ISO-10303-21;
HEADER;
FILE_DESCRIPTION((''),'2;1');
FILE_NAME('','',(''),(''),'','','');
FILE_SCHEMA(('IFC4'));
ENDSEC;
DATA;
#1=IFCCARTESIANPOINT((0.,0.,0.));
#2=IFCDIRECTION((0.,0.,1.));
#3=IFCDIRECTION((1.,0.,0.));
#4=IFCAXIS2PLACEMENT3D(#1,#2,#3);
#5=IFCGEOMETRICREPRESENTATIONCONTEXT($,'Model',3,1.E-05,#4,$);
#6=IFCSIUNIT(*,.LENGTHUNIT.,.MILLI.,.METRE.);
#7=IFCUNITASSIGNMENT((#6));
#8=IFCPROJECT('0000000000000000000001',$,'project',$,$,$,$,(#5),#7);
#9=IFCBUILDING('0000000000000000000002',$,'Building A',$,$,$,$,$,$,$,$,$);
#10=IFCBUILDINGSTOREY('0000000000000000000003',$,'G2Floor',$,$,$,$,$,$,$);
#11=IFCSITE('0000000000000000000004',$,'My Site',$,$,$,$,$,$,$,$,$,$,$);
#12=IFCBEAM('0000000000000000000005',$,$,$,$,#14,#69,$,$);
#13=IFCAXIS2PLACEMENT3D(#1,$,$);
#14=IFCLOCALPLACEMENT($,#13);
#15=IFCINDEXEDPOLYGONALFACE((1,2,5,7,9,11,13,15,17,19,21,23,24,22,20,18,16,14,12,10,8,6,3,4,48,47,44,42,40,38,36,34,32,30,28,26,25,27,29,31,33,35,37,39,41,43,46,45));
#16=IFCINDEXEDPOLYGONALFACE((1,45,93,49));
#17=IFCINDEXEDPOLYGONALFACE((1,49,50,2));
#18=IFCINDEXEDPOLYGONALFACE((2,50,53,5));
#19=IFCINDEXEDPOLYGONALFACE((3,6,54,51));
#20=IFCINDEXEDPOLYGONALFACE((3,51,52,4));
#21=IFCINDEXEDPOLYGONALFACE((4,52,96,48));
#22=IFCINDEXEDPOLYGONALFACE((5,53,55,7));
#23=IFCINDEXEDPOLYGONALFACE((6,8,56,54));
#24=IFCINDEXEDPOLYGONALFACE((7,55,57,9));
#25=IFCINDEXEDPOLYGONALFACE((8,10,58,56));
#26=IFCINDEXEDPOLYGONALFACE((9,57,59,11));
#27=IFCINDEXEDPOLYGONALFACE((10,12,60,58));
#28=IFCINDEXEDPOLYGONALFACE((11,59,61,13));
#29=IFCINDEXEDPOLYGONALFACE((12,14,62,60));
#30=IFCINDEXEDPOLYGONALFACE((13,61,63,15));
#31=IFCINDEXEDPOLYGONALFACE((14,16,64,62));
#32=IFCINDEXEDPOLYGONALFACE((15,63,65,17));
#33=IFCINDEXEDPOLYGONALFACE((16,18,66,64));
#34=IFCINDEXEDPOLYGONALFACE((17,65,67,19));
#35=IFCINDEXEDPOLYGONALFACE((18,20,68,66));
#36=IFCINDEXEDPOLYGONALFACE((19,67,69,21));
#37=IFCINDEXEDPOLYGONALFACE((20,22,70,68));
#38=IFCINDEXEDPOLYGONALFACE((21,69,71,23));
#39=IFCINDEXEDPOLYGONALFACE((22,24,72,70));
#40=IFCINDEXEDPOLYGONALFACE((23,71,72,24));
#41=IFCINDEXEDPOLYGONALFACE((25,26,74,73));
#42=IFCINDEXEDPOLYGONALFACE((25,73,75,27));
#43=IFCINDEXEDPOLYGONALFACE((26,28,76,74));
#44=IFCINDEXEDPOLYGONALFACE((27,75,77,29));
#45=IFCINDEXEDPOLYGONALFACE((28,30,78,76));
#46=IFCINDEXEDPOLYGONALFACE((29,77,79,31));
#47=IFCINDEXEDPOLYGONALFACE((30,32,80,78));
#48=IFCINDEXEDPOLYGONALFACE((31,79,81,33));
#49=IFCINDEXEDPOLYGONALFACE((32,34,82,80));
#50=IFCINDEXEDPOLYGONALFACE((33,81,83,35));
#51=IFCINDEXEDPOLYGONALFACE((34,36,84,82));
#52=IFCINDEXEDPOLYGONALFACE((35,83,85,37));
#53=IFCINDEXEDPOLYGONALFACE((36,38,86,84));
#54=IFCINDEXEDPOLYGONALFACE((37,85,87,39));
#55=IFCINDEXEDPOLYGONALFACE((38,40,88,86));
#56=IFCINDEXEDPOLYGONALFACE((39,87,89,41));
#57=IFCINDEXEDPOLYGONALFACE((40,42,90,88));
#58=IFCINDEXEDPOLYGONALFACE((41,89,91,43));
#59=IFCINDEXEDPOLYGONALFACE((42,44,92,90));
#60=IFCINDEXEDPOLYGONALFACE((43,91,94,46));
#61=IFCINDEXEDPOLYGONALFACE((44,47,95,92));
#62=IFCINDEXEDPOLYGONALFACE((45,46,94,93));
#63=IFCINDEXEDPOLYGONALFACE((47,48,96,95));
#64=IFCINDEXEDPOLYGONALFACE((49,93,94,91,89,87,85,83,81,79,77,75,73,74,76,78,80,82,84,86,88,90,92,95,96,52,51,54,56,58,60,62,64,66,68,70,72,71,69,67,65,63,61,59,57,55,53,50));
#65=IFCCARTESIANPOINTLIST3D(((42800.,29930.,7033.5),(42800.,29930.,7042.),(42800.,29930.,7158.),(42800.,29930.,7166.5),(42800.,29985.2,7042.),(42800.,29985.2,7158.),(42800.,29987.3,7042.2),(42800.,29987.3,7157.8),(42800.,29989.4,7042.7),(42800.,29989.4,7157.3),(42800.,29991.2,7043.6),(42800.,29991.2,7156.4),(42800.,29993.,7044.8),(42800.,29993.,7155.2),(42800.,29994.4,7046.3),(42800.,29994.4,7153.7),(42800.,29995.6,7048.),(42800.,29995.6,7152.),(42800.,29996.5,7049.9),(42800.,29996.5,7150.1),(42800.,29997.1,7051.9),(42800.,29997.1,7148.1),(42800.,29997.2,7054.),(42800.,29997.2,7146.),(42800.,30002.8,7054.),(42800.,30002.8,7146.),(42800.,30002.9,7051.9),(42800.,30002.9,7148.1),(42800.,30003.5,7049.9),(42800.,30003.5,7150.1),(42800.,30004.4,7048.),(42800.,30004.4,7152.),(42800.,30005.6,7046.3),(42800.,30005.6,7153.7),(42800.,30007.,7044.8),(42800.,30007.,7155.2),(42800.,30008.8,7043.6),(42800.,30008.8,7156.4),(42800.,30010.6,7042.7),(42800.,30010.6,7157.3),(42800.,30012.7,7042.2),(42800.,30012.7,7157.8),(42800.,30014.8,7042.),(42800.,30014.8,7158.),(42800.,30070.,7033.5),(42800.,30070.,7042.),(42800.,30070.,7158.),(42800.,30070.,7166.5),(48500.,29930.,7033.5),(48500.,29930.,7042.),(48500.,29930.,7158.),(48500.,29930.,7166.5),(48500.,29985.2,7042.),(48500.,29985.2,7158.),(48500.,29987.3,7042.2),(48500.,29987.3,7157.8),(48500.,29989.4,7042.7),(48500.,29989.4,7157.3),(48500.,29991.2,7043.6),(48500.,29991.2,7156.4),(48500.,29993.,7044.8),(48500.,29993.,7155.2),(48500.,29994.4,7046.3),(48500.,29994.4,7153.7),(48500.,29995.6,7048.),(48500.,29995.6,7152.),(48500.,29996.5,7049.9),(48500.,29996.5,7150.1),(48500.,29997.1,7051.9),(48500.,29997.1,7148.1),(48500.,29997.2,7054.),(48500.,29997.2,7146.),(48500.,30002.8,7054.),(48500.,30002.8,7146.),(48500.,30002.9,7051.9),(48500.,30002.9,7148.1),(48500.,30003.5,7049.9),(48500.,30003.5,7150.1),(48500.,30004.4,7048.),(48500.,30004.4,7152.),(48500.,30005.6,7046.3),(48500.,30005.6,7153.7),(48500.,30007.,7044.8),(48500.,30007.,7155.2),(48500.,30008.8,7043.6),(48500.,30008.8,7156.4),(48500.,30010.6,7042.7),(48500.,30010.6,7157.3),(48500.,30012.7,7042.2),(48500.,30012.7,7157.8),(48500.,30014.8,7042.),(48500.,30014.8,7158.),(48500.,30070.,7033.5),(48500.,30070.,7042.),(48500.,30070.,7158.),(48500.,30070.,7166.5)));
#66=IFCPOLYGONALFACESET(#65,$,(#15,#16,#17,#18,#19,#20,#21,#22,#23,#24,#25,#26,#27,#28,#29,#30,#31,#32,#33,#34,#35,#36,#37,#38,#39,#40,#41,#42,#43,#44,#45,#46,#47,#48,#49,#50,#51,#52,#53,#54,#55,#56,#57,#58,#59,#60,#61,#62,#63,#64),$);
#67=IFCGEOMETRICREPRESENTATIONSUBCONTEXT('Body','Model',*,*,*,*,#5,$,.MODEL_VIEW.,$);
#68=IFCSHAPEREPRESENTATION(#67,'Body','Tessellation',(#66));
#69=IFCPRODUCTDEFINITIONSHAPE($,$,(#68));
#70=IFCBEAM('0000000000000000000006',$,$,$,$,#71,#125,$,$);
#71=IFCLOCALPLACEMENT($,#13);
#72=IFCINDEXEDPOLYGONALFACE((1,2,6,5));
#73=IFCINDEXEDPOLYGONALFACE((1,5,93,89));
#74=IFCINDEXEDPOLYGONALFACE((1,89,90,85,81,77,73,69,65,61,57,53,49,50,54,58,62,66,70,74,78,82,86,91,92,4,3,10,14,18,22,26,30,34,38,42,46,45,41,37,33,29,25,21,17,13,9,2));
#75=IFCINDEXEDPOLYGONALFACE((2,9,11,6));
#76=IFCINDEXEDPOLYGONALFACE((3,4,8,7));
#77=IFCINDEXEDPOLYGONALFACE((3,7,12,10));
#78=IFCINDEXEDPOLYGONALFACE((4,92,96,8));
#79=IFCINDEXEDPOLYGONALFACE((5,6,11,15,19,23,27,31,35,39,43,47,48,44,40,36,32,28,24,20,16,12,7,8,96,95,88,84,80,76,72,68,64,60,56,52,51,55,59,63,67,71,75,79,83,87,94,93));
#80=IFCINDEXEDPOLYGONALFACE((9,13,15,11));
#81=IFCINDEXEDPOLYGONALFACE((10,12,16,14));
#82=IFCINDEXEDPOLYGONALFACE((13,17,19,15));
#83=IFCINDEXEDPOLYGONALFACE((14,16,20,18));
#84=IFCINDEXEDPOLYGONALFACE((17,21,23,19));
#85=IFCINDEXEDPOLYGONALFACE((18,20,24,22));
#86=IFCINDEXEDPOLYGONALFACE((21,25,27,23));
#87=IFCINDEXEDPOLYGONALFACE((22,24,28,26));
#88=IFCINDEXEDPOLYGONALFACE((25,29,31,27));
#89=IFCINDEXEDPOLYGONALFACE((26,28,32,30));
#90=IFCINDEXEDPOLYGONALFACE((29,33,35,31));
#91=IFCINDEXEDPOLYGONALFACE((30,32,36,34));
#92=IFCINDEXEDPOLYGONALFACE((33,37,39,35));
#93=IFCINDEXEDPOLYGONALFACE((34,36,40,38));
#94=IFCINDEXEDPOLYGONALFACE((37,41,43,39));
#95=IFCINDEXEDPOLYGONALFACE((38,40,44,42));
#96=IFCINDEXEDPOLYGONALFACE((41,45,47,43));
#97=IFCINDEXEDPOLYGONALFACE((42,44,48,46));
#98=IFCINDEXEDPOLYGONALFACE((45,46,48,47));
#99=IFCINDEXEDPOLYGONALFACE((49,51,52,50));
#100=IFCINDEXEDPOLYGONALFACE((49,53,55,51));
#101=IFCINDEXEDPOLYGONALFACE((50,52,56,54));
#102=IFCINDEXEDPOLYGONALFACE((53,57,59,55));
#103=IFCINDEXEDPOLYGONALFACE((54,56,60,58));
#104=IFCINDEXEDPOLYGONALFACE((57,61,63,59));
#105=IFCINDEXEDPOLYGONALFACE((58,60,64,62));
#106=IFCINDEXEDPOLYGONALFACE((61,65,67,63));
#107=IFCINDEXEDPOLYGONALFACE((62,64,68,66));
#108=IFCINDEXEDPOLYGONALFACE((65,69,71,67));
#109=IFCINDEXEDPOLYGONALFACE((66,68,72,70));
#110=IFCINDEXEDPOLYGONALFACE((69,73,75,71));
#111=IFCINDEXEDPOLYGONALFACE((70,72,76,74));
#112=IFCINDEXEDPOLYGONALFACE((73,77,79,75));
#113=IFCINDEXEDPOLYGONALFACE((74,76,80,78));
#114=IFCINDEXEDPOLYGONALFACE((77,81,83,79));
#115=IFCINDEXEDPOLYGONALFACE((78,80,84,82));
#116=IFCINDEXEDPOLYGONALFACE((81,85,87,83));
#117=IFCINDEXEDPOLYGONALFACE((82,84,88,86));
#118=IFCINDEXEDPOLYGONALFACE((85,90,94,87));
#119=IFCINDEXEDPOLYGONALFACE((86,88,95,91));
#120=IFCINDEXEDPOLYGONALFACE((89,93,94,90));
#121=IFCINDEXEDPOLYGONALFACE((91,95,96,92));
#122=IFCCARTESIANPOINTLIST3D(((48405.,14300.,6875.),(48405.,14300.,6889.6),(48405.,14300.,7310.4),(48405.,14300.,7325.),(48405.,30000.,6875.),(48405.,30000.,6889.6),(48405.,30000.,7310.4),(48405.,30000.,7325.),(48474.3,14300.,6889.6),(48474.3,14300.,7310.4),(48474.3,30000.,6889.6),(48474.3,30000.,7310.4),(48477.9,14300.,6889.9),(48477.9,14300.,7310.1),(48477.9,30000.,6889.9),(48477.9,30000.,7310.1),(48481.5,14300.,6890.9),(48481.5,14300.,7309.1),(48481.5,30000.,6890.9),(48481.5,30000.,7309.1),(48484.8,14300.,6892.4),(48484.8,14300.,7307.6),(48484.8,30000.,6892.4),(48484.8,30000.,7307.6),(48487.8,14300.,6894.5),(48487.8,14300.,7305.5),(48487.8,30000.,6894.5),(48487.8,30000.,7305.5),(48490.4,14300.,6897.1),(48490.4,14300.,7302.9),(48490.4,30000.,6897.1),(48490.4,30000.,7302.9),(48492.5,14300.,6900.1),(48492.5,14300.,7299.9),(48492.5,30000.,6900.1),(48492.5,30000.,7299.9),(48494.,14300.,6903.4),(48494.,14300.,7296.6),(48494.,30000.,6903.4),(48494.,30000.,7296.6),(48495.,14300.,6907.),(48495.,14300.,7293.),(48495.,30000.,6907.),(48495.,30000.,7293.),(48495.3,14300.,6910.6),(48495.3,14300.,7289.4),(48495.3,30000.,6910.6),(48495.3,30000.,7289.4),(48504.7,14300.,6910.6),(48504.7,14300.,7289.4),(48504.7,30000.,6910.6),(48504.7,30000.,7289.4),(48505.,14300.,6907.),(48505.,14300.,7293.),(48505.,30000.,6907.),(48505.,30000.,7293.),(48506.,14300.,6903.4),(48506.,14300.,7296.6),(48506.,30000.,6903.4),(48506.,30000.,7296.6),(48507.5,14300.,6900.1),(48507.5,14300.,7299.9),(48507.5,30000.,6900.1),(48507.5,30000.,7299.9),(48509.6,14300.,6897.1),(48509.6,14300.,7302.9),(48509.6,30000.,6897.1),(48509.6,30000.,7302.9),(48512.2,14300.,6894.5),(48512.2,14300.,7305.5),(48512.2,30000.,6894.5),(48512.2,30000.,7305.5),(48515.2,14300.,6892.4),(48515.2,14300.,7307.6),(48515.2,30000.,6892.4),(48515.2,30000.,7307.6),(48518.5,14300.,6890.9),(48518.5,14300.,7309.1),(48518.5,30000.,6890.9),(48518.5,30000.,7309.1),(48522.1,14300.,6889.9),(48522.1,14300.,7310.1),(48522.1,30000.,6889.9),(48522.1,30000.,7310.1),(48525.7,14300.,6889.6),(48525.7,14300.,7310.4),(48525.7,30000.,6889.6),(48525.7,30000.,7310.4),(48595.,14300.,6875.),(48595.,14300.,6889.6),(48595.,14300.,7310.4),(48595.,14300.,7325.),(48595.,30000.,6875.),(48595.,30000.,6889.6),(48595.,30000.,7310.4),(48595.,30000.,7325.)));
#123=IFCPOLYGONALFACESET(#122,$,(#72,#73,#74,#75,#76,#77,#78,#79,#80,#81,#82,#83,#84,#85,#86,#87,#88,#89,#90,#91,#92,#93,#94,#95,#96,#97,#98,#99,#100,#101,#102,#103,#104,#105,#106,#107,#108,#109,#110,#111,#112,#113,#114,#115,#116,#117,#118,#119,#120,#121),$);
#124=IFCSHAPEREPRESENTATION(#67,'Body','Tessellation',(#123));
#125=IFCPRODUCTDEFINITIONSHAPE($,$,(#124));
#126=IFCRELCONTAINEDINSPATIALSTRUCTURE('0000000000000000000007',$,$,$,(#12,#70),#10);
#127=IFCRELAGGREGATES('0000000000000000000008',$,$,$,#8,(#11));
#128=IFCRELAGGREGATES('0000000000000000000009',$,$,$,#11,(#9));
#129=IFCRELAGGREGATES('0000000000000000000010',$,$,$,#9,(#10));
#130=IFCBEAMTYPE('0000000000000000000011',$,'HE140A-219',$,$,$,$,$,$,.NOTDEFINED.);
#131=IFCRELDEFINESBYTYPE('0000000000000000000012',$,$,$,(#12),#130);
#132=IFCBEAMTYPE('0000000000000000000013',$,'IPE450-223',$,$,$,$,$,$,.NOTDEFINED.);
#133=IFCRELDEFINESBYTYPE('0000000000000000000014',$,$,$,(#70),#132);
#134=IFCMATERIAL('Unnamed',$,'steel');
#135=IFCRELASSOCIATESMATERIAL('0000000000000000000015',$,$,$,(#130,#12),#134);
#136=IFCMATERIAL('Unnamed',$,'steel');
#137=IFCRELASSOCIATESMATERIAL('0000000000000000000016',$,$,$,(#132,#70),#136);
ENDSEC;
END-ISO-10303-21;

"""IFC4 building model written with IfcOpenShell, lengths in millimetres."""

from ifc_helpers import new_model, si_unit, frame, origin_with_axes, place, context, subcontext, project, spatial, polyline, outline, extrude, material, material_profile, profile_set, profile_usage, type_object, element, save


model = new_model("IFC4")

# Units and contexts
model_context = context("Model", 3, precision=1e-05, world=origin_with_axes())
body_context = subcontext(model_context, "Body", "Model", "MODEL_VIEW")
ifc_project = project(units=[si_unit("LENGTHUNIT", "METRE", prefix="MILLI")], contexts=[model_context])

# Site, building, storey
site = spatial("IfcSite", under=ifc_project, Name="My Site")
building = spatial("IfcBuilding", under=site, Name="Building A")
storey = spatial("IfcBuildingStorey", under=building, Name="G2Floor")

# Beams
ifc_material_1 = material(Name="Unnamed", Category="steel")
ifc_material_profile_1 = material_profile(ifc_material_1, outline(polyline([(70.0, -66.5), (70.0, -58.0), (70.0, -58.0), (14.8, -58.0), (14.8, -58.0), (12.7, -57.8), (12.7, -57.8), (10.6, -57.3), (10.6, -57.3), (8.8, -56.4), (8.8, -56.4), (7.0, -55.2), (7.0, -55.2), (5.6, -53.7), (5.6, -53.7), (4.4, -52.0), (4.4, -52.0), (3.5, -50.1), (3.5, -50.1), (2.9, -48.1), (2.9, -48.1), (2.8, -46.0), (2.8, -46.0), (2.8, 46.0), (2.8, 46.0), (2.9, 48.1), (2.9, 48.1), (3.5, 50.1), (3.5, 50.1), (4.4, 52.0), (4.4, 52.0), (5.6, 53.7), (5.6, 53.7), (7.0, 55.2), (7.0, 55.2), (8.8, 56.4), (8.8, 56.4), (10.6, 57.3), (10.6, 57.3), (12.7, 57.8), (12.7, 57.8), (14.8, 58.0), (14.8, 58.0), (70.0, 58.0), (70.0, 58.0), (70.0, 66.5), (70.0, 66.5), (-70.0, 66.5), (-70.0, 66.5), (-70.0, 58.0), (-70.0, 58.0), (-14.8, 58.0), (-14.8, 58.0), (-12.7, 57.8), (-12.7, 57.8), (-10.6, 57.3), (-10.6, 57.3), (-8.8, 56.4), (-8.8, 56.4), (-7.0, 55.2), (-7.0, 55.2), (-5.6, 53.7), (-5.6, 53.7), (-4.4, 52.0), (-4.4, 52.0), (-3.5, 50.1), (-3.5, 50.1), (-2.9, 48.1), (-2.9, 48.1), (-2.8, 46.0), (-2.8, 46.0), (-2.8, -46.0), (-2.8, -46.0), (-2.9, -48.1), (-2.9, -48.1), (-3.5, -50.1), (-3.5, -50.1), (-4.4, -52.0), (-4.4, -52.0), (-5.6, -53.7), (-5.6, -53.7), (-7.0, -55.2), (-7.0, -55.2), (-8.8, -56.4), (-8.8, -56.4), (-10.6, -57.3), (-10.6, -57.3), (-12.7, -57.8), (-12.7, -57.8), (-14.8, -58.0), (-14.8, -58.0), (-70.0, -58.0), (-70.0, -58.0), (-70.0, -66.5), (-70.0, -66.5), (70.0, -66.5)])))
ifc_profile_set_1 = profile_set([ifc_material_profile_1], Name="HE140A-219")
ifc_profile_usage_1 = profile_usage(ifc_profile_set_1)
beam_type_1 = type_object("IfcBeamType", Name="HE140A-219", PredefinedType="NOTDEFINED", material=ifc_profile_set_1)
beam_1_placement = place(None, frame((42800.0, 30000.0, 7100.0), z_axis=(1.0, 0.0, 0.0), x_axis=(0.0, -1.0, 0.0)))
element("IfcBeam", 1, at=beam_1_placement, inside=storey, type_object=beam_type_1, material=ifc_profile_usage_1, context=body_context, shape_type="SweptSolid", body=[
    extrude(outline(polyline([(70.0, -66.5), (70.0, -58.0), (70.0, -58.0), (14.8, -58.0), (14.8, -58.0), (12.7, -57.8), (12.7, -57.8), (10.6, -57.3), (10.6, -57.3), (8.8, -56.4), (8.8, -56.4), (7.0, -55.2), (7.0, -55.2), (5.6, -53.7), (5.6, -53.7), (4.4, -52.0), (4.4, -52.0), (3.5, -50.1), (3.5, -50.1), (2.9, -48.1), (2.9, -48.1), (2.8, -46.0), (2.8, -46.0), (2.8, 46.0), (2.8, 46.0), (2.9, 48.1), (2.9, 48.1), (3.5, 50.1), (3.5, 50.1), (4.4, 52.0), (4.4, 52.0), (5.6, 53.7), (5.6, 53.7), (7.0, 55.2), (7.0, 55.2), (8.8, 56.4), (8.8, 56.4), (10.6, 57.3), (10.6, 57.3), (12.7, 57.8), (12.7, 57.8), (14.8, 58.0), (14.8, 58.0), (70.0, 58.0), (70.0, 58.0), (70.0, 66.5), (70.0, 66.5), (-70.0, 66.5), (-70.0, 66.5), (-70.0, 58.0), (-70.0, 58.0), (-14.8, 58.0), (-14.8, 58.0), (-12.7, 57.8), (-12.7, 57.8), (-10.6, 57.3), (-10.6, 57.3), (-8.8, 56.4), (-8.8, 56.4), (-7.0, 55.2), (-7.0, 55.2), (-5.6, 53.7), (-5.6, 53.7), (-4.4, 52.0), (-4.4, 52.0), (-3.5, 50.1), (-3.5, 50.1), (-2.9, 48.1), (-2.9, 48.1), (-2.8, 46.0), (-2.8, 46.0), (-2.8, -46.0), (-2.8, -46.0), (-2.9, -48.1), (-2.9, -48.1), (-3.5, -50.1), (-3.5, -50.1), (-4.4, -52.0), (-4.4, -52.0), (-5.6, -53.7), (-5.6, -53.7), (-7.0, -55.2), (-7.0, -55.2), (-8.8, -56.4), (-8.8, -56.4), (-10.6, -57.3), (-10.6, -57.3), (-12.7, -57.8), (-12.7, -57.8), (-14.8, -58.0), (-14.8, -58.0), (-70.0, -58.0), (-70.0, -58.0), (-70.0, -66.5), (-70.0, -66.5), (70.0, -66.5)])), origin_with_axes(), (0.0, 0.0, 1.0), 5700.0),
])
ifc_material_2 = material(Name="Unnamed", Category="steel")
ifc_material_profile_2 = material_profile(ifc_material_2, outline(polyline([(95.0, -225.0), (95.0, -210.4), (95.0, -210.4), (25.7, -210.4), (25.7, -210.4), (22.1, -210.1), (22.1, -210.1), (18.5, -209.1), (18.5, -209.1), (15.2, -207.6), (15.2, -207.6), (12.2, -205.5), (12.2, -205.5), (9.6, -202.9), (9.6, -202.9), (7.5, -199.9), (7.5, -199.9), (6.0, -196.6), (6.0, -196.6), (5.0, -193.0), (5.0, -193.0), (4.7, -189.4), (4.7, -189.4), (4.7, 189.4), (4.7, 189.4), (5.0, 193.0), (5.0, 193.0), (6.0, 196.6), (6.0, 196.6), (7.5, 199.9), (7.5, 199.9), (9.6, 202.9), (9.6, 202.9), (12.2, 205.5), (12.2, 205.5), (15.2, 207.6), (15.2, 207.6), (18.5, 209.1), (18.5, 209.1), (22.1, 210.1), (22.1, 210.1), (25.7, 210.4), (25.7, 210.4), (95.0, 210.4), (95.0, 210.4), (95.0, 225.0), (95.0, 225.0), (-95.0, 225.0), (-95.0, 225.0), (-95.0, 210.4), (-95.0, 210.4), (-25.7, 210.4), (-25.7, 210.4), (-22.1, 210.1), (-22.1, 210.1), (-18.5, 209.1), (-18.5, 209.1), (-15.2, 207.6), (-15.2, 207.6), (-12.2, 205.5), (-12.2, 205.5), (-9.6, 202.9), (-9.6, 202.9), (-7.5, 199.9), (-7.5, 199.9), (-6.0, 196.6), (-6.0, 196.6), (-5.0, 193.0), (-5.0, 193.0), (-4.7, 189.4), (-4.7, 189.4), (-4.7, -189.4), (-4.7, -189.4), (-5.0, -193.0), (-5.0, -193.0), (-6.0, -196.6), (-6.0, -196.6), (-7.5, -199.9), (-7.5, -199.9), (-9.6, -202.9), (-9.6, -202.9), (-12.2, -205.5), (-12.2, -205.5), (-15.2, -207.6), (-15.2, -207.6), (-18.5, -209.1), (-18.5, -209.1), (-22.1, -210.1), (-22.1, -210.1), (-25.7, -210.4), (-25.7, -210.4), (-95.0, -210.4), (-95.0, -210.4), (-95.0, -225.0), (-95.0, -225.0), (95.0, -225.0)])))
ifc_profile_set_2 = profile_set([ifc_material_profile_2], Name="IPE450-223")
ifc_profile_usage_2 = profile_usage(ifc_profile_set_2)
beam_type_2 = type_object("IfcBeamType", Name="IPE450-223", PredefinedType="NOTDEFINED", material=ifc_profile_set_2)
beam_2_placement = place(None, frame((48500.0, 14300.0, 7100.0), z_axis=(0.0, 1.0, 0.0), x_axis=(1.0, 0.0, 0.0)))
element("IfcBeam", 2, at=beam_2_placement, inside=storey, type_object=beam_type_2, material=ifc_profile_usage_2, context=body_context, shape_type="SweptSolid", body=[
    extrude(outline(polyline([(95.0, -225.0), (95.0, -210.4), (95.0, -210.4), (25.7, -210.4), (25.7, -210.4), (22.1, -210.1), (22.1, -210.1), (18.5, -209.1), (18.5, -209.1), (15.2, -207.6), (15.2, -207.6), (12.2, -205.5), (12.2, -205.5), (9.6, -202.9), (9.6, -202.9), (7.5, -199.9), (7.5, -199.9), (6.0, -196.6), (6.0, -196.6), (5.0, -193.0), (5.0, -193.0), (4.7, -189.4), (4.7, -189.4), (4.7, 189.4), (4.7, 189.4), (5.0, 193.0), (5.0, 193.0), (6.0, 196.6), (6.0, 196.6), (7.5, 199.9), (7.5, 199.9), (9.6, 202.9), (9.6, 202.9), (12.2, 205.5), (12.2, 205.5), (15.2, 207.6), (15.2, 207.6), (18.5, 209.1), (18.5, 209.1), (22.1, 210.1), (22.1, 210.1), (25.7, 210.4), (25.7, 210.4), (95.0, 210.4), (95.0, 210.4), (95.0, 225.0), (95.0, 225.0), (-95.0, 225.0), (-95.0, 225.0), (-95.0, 210.4), (-95.0, 210.4), (-25.7, 210.4), (-25.7, 210.4), (-22.1, 210.1), (-22.1, 210.1), (-18.5, 209.1), (-18.5, 209.1), (-15.2, 207.6), (-15.2, 207.6), (-12.2, 205.5), (-12.2, 205.5), (-9.6, 202.9), (-9.6, 202.9), (-7.5, 199.9), (-7.5, 199.9), (-6.0, 196.6), (-6.0, 196.6), (-5.0, 193.0), (-5.0, 193.0), (-4.7, 189.4), (-4.7, 189.4), (-4.7, -189.4), (-4.7, -189.4), (-5.0, -193.0), (-5.0, -193.0), (-6.0, -196.6), (-6.0, -196.6), (-7.5, -199.9), (-7.5, -199.9), (-9.6, -202.9), (-9.6, -202.9), (-12.2, -205.5), (-12.2, -205.5), (-15.2, -207.6), (-15.2, -207.6), (-18.5, -209.1), (-18.5, -209.1), (-22.1, -210.1), (-22.1, -210.1), (-25.7, -210.4), (-25.7, -210.4), (-95.0, -210.4), (-95.0, -210.4), (-95.0, -225.0), (-95.0, -225.0), (95.0, -225.0)])), origin_with_axes(), (0.0, 0.0, 1.0), 15700.0),
])

save(model, "model.ifc")
